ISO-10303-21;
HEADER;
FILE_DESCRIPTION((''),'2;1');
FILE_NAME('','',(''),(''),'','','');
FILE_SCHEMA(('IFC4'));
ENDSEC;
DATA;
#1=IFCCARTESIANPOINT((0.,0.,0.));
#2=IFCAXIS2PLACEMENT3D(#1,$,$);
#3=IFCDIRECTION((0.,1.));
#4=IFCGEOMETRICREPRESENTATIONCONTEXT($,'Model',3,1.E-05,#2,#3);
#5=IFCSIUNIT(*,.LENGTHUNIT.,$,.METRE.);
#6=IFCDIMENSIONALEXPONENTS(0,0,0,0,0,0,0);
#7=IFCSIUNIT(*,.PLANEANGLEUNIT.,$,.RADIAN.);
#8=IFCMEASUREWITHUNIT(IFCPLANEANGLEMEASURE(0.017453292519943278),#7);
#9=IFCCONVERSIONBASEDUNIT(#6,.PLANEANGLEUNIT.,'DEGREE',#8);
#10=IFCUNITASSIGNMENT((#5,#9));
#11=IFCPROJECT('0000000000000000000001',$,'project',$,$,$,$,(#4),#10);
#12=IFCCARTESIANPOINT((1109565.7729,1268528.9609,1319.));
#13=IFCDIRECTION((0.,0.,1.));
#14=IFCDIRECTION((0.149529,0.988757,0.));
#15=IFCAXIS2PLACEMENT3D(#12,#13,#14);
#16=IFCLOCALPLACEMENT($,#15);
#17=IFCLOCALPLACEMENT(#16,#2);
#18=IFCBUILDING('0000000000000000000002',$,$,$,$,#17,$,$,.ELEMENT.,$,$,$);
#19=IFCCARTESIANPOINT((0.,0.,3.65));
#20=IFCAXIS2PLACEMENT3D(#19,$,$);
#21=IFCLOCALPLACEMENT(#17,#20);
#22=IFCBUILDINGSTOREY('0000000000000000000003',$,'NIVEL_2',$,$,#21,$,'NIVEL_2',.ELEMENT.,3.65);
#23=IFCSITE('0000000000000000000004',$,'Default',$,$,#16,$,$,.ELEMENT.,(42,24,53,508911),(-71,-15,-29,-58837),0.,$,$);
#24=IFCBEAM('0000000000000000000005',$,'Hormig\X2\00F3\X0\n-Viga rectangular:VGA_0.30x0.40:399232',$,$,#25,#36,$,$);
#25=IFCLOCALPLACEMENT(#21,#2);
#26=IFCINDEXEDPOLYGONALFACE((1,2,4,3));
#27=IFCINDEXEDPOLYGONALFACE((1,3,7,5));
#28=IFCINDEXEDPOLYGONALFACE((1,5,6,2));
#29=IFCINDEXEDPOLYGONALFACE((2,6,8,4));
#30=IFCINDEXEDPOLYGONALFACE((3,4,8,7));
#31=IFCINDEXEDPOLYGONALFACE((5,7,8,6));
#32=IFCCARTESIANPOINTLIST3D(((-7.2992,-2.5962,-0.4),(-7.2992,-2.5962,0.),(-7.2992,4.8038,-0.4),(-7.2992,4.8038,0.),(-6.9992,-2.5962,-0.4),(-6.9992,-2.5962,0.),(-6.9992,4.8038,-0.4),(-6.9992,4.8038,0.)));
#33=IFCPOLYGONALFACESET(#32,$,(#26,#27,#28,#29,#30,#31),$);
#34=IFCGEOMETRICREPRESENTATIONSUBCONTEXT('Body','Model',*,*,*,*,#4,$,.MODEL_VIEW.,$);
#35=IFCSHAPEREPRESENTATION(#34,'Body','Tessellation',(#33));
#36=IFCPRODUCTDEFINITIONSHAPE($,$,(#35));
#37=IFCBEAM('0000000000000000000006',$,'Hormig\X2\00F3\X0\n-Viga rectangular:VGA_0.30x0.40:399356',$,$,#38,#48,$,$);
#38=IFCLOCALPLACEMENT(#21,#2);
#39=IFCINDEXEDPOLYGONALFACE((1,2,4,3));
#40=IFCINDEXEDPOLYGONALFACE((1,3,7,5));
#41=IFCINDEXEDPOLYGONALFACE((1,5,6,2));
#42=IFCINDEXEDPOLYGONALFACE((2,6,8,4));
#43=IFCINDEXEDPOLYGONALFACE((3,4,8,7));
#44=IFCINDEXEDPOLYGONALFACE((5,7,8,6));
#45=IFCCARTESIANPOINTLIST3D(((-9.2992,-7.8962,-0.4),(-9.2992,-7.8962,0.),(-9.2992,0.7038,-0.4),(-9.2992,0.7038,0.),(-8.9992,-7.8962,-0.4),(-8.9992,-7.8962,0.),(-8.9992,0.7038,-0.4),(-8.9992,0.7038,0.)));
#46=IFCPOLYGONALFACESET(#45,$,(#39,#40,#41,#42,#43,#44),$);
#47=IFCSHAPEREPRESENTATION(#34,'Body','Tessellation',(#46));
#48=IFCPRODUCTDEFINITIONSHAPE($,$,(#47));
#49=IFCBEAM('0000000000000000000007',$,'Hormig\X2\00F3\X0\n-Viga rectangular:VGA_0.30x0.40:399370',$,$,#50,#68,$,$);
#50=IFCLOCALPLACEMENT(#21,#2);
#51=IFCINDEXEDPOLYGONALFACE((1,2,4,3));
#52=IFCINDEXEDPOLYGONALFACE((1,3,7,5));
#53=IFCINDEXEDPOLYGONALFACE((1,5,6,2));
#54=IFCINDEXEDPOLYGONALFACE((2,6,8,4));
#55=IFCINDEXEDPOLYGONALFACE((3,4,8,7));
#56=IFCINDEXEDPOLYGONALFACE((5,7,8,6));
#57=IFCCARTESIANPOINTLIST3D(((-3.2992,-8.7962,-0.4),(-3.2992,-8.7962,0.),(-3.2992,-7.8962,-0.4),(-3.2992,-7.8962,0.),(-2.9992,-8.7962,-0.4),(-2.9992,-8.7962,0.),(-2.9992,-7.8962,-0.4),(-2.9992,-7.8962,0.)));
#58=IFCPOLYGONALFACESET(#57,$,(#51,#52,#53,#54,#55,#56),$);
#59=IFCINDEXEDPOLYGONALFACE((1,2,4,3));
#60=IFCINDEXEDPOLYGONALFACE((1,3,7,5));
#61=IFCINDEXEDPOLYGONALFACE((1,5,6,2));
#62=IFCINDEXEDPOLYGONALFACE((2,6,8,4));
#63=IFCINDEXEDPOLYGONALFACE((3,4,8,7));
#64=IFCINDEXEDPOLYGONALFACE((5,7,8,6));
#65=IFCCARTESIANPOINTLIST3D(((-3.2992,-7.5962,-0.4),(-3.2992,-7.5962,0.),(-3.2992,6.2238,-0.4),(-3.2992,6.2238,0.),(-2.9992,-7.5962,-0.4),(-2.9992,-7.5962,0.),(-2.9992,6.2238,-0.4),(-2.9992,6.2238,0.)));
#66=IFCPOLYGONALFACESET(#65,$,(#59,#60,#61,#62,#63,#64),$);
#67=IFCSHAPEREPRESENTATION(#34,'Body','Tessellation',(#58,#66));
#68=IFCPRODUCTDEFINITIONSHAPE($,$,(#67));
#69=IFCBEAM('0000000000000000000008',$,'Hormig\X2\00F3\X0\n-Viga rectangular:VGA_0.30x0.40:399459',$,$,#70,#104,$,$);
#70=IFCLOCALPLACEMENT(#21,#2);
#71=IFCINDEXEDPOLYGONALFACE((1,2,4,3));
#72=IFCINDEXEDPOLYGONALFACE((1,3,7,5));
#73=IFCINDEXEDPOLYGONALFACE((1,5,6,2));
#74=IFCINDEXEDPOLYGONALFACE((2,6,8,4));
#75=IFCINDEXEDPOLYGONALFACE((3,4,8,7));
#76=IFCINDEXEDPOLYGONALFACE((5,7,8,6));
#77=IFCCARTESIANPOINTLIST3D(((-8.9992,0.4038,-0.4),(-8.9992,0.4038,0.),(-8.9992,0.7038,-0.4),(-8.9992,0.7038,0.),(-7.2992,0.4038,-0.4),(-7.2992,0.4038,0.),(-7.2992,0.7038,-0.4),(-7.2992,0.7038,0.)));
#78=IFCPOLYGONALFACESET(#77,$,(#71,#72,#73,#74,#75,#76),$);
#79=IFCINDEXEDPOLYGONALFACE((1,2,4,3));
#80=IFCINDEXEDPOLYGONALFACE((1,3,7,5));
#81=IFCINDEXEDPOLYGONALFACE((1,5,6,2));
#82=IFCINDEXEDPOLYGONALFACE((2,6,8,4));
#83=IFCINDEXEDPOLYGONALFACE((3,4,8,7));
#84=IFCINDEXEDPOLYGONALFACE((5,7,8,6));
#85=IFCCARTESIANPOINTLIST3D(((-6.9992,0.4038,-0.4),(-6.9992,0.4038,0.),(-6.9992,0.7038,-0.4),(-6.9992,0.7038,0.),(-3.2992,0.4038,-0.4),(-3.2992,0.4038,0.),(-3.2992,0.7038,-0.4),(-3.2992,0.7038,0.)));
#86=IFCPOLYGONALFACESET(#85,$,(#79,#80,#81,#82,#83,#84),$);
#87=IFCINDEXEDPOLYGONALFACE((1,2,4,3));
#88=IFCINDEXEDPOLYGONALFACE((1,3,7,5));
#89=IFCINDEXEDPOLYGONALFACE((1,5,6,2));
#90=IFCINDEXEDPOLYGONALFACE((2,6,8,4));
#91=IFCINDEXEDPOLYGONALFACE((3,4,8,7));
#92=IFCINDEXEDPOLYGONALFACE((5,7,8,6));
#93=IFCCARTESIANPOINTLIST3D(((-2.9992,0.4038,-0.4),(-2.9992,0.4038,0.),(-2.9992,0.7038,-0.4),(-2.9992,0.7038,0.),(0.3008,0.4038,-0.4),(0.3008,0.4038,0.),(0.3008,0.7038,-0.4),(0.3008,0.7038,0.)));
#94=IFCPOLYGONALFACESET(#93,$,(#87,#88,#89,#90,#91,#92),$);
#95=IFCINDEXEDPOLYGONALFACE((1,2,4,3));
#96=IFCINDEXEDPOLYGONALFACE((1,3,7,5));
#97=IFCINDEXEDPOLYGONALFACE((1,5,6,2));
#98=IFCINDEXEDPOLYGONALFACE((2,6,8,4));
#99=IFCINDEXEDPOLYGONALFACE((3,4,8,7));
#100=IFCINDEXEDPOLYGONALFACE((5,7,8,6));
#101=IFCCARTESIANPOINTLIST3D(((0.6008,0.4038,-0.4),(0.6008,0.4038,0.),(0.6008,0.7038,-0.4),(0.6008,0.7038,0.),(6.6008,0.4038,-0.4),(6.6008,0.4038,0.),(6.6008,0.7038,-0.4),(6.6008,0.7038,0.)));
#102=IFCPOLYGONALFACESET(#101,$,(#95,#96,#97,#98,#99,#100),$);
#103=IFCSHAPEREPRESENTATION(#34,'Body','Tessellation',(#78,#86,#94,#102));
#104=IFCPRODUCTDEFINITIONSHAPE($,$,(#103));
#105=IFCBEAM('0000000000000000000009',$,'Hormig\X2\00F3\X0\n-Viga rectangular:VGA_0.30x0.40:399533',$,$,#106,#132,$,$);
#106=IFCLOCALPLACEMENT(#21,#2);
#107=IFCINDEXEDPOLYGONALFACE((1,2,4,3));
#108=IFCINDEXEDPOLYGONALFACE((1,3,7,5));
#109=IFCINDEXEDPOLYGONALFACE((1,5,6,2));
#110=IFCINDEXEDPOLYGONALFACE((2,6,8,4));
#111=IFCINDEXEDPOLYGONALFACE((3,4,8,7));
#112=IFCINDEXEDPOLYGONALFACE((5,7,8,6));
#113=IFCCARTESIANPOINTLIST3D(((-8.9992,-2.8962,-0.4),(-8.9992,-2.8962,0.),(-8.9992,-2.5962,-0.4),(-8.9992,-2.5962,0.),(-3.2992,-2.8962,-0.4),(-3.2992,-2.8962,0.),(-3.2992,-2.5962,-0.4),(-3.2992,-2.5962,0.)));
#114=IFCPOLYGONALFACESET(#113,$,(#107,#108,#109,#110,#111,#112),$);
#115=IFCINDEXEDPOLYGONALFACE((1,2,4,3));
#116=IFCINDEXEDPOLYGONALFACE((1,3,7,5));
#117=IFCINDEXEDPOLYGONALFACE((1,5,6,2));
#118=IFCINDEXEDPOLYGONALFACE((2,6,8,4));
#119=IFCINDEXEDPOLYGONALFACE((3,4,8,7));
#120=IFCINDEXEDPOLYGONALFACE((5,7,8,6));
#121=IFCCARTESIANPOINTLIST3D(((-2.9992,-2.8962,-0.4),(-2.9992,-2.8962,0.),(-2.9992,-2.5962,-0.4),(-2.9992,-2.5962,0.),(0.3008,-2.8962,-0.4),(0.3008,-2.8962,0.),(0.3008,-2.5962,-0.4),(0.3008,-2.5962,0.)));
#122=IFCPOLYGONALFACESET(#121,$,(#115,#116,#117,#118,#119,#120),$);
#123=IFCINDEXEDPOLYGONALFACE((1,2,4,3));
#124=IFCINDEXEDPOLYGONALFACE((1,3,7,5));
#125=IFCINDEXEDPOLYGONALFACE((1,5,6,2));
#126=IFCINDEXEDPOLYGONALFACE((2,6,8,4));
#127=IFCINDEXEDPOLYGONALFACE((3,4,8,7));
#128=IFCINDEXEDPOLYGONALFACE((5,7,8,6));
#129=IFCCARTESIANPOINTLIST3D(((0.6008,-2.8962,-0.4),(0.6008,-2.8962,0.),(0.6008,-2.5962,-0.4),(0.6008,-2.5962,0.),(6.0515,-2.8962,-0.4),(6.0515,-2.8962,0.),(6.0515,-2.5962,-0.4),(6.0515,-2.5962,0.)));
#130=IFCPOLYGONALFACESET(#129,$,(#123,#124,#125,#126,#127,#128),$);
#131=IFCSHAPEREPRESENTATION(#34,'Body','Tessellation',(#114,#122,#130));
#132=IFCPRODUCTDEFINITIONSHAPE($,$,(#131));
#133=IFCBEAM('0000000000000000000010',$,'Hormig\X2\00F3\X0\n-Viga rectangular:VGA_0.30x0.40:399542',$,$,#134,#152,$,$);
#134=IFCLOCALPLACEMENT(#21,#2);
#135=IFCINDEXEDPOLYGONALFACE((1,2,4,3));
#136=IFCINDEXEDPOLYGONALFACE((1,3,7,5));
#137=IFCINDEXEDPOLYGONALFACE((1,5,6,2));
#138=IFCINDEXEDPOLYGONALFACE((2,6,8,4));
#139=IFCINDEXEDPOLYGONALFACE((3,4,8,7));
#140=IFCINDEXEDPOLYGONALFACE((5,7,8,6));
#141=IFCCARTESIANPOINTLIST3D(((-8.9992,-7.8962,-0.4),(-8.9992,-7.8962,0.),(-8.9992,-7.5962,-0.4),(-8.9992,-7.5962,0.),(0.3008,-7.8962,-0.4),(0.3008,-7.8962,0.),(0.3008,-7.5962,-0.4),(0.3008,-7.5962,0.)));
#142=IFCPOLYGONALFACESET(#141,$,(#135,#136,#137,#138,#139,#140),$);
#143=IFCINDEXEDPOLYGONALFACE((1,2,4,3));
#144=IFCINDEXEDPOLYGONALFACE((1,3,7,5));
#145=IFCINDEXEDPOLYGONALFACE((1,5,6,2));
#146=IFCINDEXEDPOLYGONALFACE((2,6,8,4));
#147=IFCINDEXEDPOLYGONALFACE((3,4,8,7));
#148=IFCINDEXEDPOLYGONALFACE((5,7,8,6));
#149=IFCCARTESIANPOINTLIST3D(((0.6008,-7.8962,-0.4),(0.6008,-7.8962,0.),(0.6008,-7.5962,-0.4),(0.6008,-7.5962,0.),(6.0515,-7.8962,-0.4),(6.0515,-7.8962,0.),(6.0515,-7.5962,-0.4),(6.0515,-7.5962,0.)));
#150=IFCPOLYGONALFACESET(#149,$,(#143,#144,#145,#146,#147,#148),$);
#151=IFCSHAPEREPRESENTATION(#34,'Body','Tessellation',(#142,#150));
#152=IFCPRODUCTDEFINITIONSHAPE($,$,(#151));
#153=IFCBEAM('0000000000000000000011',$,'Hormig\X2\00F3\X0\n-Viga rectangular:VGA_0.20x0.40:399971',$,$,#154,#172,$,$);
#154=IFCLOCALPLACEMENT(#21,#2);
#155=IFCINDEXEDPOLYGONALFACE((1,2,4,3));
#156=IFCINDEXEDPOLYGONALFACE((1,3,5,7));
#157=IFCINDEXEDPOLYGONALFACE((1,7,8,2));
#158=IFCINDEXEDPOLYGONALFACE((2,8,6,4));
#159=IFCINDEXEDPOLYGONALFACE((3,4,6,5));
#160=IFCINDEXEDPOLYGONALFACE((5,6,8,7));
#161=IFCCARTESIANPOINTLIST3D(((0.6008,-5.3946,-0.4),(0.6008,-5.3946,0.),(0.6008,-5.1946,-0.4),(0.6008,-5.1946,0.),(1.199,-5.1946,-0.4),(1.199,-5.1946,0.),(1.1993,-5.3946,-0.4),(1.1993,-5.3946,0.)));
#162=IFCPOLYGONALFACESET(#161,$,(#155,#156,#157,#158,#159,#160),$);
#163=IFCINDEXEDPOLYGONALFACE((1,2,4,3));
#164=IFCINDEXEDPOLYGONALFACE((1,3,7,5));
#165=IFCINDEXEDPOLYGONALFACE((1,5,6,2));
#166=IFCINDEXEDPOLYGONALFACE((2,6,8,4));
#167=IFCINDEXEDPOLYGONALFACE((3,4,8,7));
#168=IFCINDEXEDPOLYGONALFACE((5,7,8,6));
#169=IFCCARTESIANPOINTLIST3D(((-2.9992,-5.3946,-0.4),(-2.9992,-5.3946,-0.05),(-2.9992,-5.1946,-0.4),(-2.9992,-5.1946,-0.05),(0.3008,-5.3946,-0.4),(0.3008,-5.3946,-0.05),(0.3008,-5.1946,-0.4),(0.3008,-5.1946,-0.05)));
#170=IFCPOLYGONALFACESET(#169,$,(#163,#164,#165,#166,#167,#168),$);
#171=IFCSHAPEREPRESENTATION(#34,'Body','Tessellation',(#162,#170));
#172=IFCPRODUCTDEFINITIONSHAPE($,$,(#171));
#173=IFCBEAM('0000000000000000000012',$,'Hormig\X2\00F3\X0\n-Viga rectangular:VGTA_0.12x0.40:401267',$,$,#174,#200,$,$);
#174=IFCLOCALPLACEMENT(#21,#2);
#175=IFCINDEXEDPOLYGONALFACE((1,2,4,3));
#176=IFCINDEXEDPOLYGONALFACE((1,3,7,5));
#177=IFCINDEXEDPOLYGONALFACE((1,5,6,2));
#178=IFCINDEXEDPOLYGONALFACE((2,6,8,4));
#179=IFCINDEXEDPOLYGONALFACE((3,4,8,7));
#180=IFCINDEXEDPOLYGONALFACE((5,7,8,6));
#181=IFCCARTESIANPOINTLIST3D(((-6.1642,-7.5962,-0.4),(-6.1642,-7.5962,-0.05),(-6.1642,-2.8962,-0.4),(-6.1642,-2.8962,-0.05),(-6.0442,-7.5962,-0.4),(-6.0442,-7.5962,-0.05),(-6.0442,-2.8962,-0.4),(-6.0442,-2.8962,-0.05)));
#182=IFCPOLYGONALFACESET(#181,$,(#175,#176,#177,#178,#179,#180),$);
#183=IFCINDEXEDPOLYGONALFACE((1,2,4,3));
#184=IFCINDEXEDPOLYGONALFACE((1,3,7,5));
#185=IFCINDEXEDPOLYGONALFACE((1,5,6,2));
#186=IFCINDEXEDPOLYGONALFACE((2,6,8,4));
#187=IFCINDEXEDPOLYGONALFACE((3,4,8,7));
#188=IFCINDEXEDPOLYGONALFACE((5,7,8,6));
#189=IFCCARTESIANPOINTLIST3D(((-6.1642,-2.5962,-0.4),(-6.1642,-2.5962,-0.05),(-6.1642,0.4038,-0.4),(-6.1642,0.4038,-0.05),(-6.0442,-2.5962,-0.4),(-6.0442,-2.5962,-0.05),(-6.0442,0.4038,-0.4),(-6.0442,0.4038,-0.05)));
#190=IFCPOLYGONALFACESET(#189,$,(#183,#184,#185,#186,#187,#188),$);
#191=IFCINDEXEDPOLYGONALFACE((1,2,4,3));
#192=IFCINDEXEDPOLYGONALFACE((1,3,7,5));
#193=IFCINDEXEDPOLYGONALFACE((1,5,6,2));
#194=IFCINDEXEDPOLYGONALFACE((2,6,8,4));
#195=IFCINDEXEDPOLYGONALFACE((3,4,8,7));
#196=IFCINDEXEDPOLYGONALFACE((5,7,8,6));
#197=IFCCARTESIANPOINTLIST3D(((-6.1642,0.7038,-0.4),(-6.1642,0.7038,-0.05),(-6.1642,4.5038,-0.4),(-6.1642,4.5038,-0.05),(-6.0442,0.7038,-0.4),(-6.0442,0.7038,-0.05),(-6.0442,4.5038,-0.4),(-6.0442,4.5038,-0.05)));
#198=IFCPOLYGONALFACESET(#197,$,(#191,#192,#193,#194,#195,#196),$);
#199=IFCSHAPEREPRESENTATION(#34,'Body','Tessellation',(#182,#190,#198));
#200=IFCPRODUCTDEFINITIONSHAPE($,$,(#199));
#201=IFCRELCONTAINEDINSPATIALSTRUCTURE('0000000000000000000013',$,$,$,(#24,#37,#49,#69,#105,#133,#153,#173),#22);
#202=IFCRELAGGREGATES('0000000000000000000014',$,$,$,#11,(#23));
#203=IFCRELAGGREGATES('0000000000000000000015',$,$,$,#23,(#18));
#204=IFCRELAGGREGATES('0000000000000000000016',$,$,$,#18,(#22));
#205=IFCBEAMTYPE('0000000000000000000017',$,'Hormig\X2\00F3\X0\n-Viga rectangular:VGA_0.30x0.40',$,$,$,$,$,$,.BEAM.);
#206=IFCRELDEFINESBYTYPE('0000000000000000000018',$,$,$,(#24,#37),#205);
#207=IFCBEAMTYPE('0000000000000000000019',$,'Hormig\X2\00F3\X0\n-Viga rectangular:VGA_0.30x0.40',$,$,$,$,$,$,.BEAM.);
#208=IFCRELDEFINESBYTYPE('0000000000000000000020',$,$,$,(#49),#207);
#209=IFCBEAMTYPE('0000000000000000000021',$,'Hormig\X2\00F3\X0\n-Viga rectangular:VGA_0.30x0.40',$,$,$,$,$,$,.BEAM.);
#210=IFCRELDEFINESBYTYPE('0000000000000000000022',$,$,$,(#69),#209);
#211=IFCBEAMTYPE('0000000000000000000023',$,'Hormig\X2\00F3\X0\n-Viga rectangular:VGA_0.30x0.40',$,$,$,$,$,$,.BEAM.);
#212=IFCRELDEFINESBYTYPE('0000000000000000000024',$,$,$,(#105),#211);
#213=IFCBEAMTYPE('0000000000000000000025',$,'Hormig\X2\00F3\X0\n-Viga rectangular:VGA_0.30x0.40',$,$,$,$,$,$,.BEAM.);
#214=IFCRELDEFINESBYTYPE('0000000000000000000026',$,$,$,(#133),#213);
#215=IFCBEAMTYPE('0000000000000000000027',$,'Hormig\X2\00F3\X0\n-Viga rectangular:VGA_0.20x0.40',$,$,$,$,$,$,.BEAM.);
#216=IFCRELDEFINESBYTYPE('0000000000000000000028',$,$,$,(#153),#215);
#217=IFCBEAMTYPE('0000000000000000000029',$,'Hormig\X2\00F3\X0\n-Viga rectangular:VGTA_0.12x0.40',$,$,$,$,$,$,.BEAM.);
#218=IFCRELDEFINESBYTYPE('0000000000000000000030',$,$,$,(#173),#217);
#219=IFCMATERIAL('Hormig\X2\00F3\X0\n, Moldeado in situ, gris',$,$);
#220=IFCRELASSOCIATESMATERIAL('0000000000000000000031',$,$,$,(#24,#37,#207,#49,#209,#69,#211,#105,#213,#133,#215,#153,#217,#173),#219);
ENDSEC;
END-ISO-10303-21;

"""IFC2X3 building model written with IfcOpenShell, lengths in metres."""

from ifc_helpers import new_model, entity, si_unit, converted_unit, direction, frame, frame_2d, origin, origin_2d_with_axis, place, context, subcontext, project, spatial, rectangle, extrude, clip, halfspace, source, transform, mapped, material, type_object, type_shapes, element, save


model = new_model("IFC2X3")

# Units and contexts
model_context = context("Model", 3, precision=1e-05, world=origin(), true_north=direction((0.0, 1.0)))
body_context = subcontext(model_context, "Body", "Model", "MODEL_VIEW")
ifc_project = project(units=[si_unit("LENGTHUNIT", "METRE"), converted_unit("PLANEANGLEUNIT", "DEGREE", entity("IfcPlaneAngleMeasure", 0.017453292519943278), si_unit("PLANEANGLEUNIT", "RADIAN"), dimensions=[0, 0, 0, 0, 0, 0, 0])], contexts=[model_context])

# Site, building, storey
site_placement = place(None, frame((1109565.7729, 1268528.9609, 1319.0), z_axis=(0.0, 0.0, 1.0), x_axis=(0.149529, 0.988757, 0.0)))
site = spatial("IfcSite", under=ifc_project, at=site_placement, Name="Default", CompositionType="ELEMENT", RefLatitude=(42, 24, 53, 508911), RefLongitude=(-71, -15, -29, -58837), RefElevation=0.0)
building_placement = place(site_placement, origin())
building = spatial("IfcBuilding", under=site, at=building_placement, CompositionType="ELEMENT")
storey_placement = place(building_placement, frame((0.0, 0.0, 3.65)))
storey = spatial("IfcBuildingStorey", under=building, at=storey_placement, Name="NIVEL_2", LongName="NIVEL_2", CompositionType="ELEMENT", Elevation=3.65)

# Shared definitions
ifc_material_1 = material(Name="Hormigón, Moldeado in situ, gris")

# Beams
beam_type_1 = type_object("IfcBeamType", Name="Hormigón-Viga rectangular:VGA_0.30x0.40", PredefinedType="BEAM")
beam_1_placement = place(storey_placement, frame((-7.1492, 4.6538, 0.0), z_axis=(0.0, 0.0, 1.0), x_axis=(0.0, -1.0, 0.0)))
element("IfcBeam", 1, at=beam_1_placement, inside=storey, type_object=beam_type_1, material=ifc_material_1, Name="Hormigón-Viga rectangular:VGA_0.30x0.40:399232", context=body_context, shape_type="SweptSolid", body=[
    extrude(rectangle(XDim=0.4, YDim=0.3, at=origin_2d_with_axis()), frame((-0.15, 0.0, -0.2), z_axis=(1.0, 0.0, 0.0), x_axis=(0.0, 0.0, -1.0)), (0.0, 0.0, 1.0), 7.4),
])
beam_2_placement = place(storey_placement, frame((-9.1492, 0.5538, 0.0), z_axis=(0.0, 0.0, 1.0), x_axis=(0.0, -1.0, 0.0)))
element("IfcBeam", 2, at=beam_2_placement, inside=storey, type_object=beam_type_1, material=ifc_material_1, Name="Hormigón-Viga rectangular:VGA_0.30x0.40:399356", context=body_context, shape_type="SweptSolid", body=[
    extrude(rectangle(XDim=0.4, YDim=0.3, at=frame_2d((0.0, 0.0), x_axis=(1.0, 0.0))), frame((-0.15, 0.0, -0.2), z_axis=(1.0, 0.0, 0.0), x_axis=(0.0, 0.0, -1.0)), (0.0, 0.0, 1.0), 8.6),
])
beam_type_2 = type_object("IfcBeamType", Name="Hormigón-Viga rectangular:VGA_0.30x0.40", PredefinedType="BEAM", material=ifc_material_1)
shared_shape_1 = source(origin(), body_context, "Body", "SweptSolid", [
    extrude(rectangle(XDim=0.4, YDim=0.3, at=frame_2d((0.0, 0.0), x_axis=(0.0, 1.0))), frame((-3.1492, -7.8962, 3.45), z_axis=(0.0, -1.0, 0.0), x_axis=(-1.0, 0.0, 0.0)), (0.0, 0.0, 1.0), 0.9),
    extrude(rectangle(XDim=0.4, YDim=0.3, at=frame_2d((0.0, 0.0), x_axis=(0.0, 1.0))), frame((-3.1492, 6.2238, 3.45), z_axis=(0.0, -1.0, 0.0), x_axis=(-1.0, 0.0, 0.0)), (0.0, 0.0, 1.0), 13.82),
])
type_shapes(beam_type_2, [shared_shape_1])
beam_3_placement = place(storey_placement, frame((0.0, 0.0, -3.65)))
element("IfcBeam", 3, at=beam_3_placement, inside=storey, type_object=beam_type_2, material=ifc_material_1, Name="Hormigón-Viga rectangular:VGA_0.30x0.40:399370", context=body_context, shape_type="MappedRepresentation", body=[
    mapped(shared_shape_1, transform((0.0, 0.0, 0.0), scale=1.0)),
])
beam_type_3 = type_object("IfcBeamType", Name="Hormigón-Viga rectangular:VGA_0.30x0.40", PredefinedType="BEAM", material=ifc_material_1)
shared_shape_2 = source(origin(), body_context, "Body", "SweptSolid", [
    extrude(rectangle(XDim=0.4, YDim=0.3, at=frame_2d((0.0, 0.0), x_axis=(1.0, 0.0))), frame((-8.9992, 0.5538, 3.45), z_axis=(1.0, 0.0, 0.0), x_axis=(0.0, 0.0, -1.0)), (0.0, 0.0, 1.0), 1.7),
    extrude(rectangle(XDim=0.4, YDim=0.3, at=frame_2d((0.0, 0.0), x_axis=(1.0, 0.0))), frame((-6.9992, 0.5538, 3.45), z_axis=(1.0, 0.0, 0.0), x_axis=(0.0, 0.0, -1.0)), (0.0, 0.0, 1.0), 3.7),
    extrude(rectangle(XDim=0.4, YDim=0.3, at=origin_2d_with_axis()), frame((-2.9992, 0.5538, 3.45), z_axis=(1.0, 0.0, 0.0), x_axis=(0.0, 0.0, -1.0)), (0.0, 0.0, 1.0), 3.3),
    extrude(rectangle(XDim=0.4, YDim=0.3, at=origin_2d_with_axis()), frame((0.6008, 0.5538, 3.45), z_axis=(1.0, 0.0, 0.0), x_axis=(0.0, 0.0, -1.0)), (0.0, 0.0, 1.0), 6.0),
])
type_shapes(beam_type_3, [shared_shape_2])
beam_4_placement = place(storey_placement, frame((0.0, 0.0, -3.65)))
element("IfcBeam", 4, at=beam_4_placement, inside=storey, type_object=beam_type_3, material=ifc_material_1, Name="Hormigón-Viga rectangular:VGA_0.30x0.40:399459", context=body_context, shape_type="MappedRepresentation", body=[
    mapped(shared_shape_2, transform((0.0, 0.0, 0.0), scale=1.0)),
])
beam_type_4 = type_object("IfcBeamType", Name="Hormigón-Viga rectangular:VGA_0.30x0.40", PredefinedType="BEAM", material=ifc_material_1)
shared_shape_3 = source(origin(), body_context, "Body", "SweptSolid", [
    extrude(rectangle(XDim=0.4, YDim=0.3, at=origin_2d_with_axis()), frame((-8.9992, -2.7462, 3.45), z_axis=(1.0, 0.0, 0.0), x_axis=(0.0, 0.0, -1.0)), (0.0, 0.0, 1.0), 5.7),
    extrude(rectangle(XDim=0.4, YDim=0.3, at=origin_2d_with_axis()), frame((-2.9992, -2.7462, 3.45), z_axis=(1.0, 0.0, 0.0), x_axis=(0.0, 0.0, -1.0)), (0.0, 0.0, 1.0), 3.3),
    extrude(rectangle(XDim=0.4, YDim=0.3, at=origin_2d_with_axis()), frame((0.6008, -2.7462, 3.45), z_axis=(1.0, 0.0, 0.0), x_axis=(0.0, 0.0, -1.0)), (0.0, 0.0, 1.0), 5.4507),
])
type_shapes(beam_type_4, [shared_shape_3])
beam_5_placement = place(storey_placement, frame((0.0, 0.0, -3.65)))
element("IfcBeam", 5, at=beam_5_placement, inside=storey, type_object=beam_type_4, material=ifc_material_1, Name="Hormigón-Viga rectangular:VGA_0.30x0.40:399533", context=body_context, shape_type="MappedRepresentation", body=[
    mapped(shared_shape_3, transform((0.0, 0.0, 0.0), scale=1.0)),
])
beam_type_5 = type_object("IfcBeamType", Name="Hormigón-Viga rectangular:VGA_0.30x0.40", PredefinedType="BEAM", material=ifc_material_1)
shared_shape_4 = source(origin(), body_context, "Body", "SweptSolid", [
    extrude(rectangle(XDim=0.4, YDim=0.3, at=frame_2d((0.0, 0.0), x_axis=(1.0, 0.0))), frame((-8.9992, -7.7462, 3.45), z_axis=(1.0, 0.0, 0.0), x_axis=(0.0, 0.0, -1.0)), (0.0, 0.0, 1.0), 9.3),
    extrude(rectangle(XDim=0.4, YDim=0.3, at=frame_2d((0.0, 0.0), x_axis=(1.0, 0.0))), frame((0.6008, -7.7462, 3.45), z_axis=(1.0, 0.0, 0.0), x_axis=(0.0, 0.0, -1.0)), (0.0, 0.0, 1.0), 5.4507),
])
type_shapes(beam_type_5, [shared_shape_4])
beam_6_placement = place(storey_placement, frame((0.0, 0.0, -3.65)))
element("IfcBeam", 6, at=beam_6_placement, inside=storey, type_object=beam_type_5, material=ifc_material_1, Name="Hormigón-Viga rectangular:VGA_0.30x0.40:399542", context=body_context, shape_type="MappedRepresentation", body=[
    mapped(shared_shape_4, transform((0.0, 0.0, 0.0), scale=1.0)),
])
beam_type_6 = type_object("IfcBeamType", Name="Hormigón-Viga rectangular:VGA_0.20x0.40", PredefinedType="BEAM", material=ifc_material_1)
shared_shape_5 = source(origin(), body_context, "Body", "SweptSolid", [
    clip(extrude(rectangle(XDim=0.4, YDim=0.2, at=frame_2d((0.0, 0.0), x_axis=(1.0, 0.0))), frame((0.6008, -5.2946, 3.45), z_axis=(1.0, 0.0, 0.0), x_axis=(0.0, 0.0, -1.0)), (0.0, 0.0, 1.0), 0.5985), halfspace(frame((1.199, -5.1946, 3.65), z_axis=(0.999999, 0.001387, 0.0), x_axis=(0.001387, -0.999999, 0.0)), False)),
    extrude(rectangle(XDim=0.35, YDim=0.2, at=frame_2d((0.0, 0.0), x_axis=(1.0, 0.0))), frame((-2.9992, -5.2946, 3.425), z_axis=(1.0, 0.0, 0.0), x_axis=(0.0, 0.0, -1.0)), (0.0, 0.0, 1.0), 3.3),
])
type_shapes(beam_type_6, [shared_shape_5])
beam_7_placement = place(storey_placement, frame((0.0, 0.0, -3.65)))
element("IfcBeam", 7, at=beam_7_placement, inside=storey, type_object=beam_type_6, material=ifc_material_1, Name="Hormigón-Viga rectangular:VGA_0.20x0.40:399971", context=body_context, shape_type="MappedRepresentation", body=[
    mapped(shared_shape_5, transform((0.0, 0.0, 0.0), scale=1.0)),
])
beam_type_7 = type_object("IfcBeamType", Name="Hormigón-Viga rectangular:VGTA_0.12x0.40", PredefinedType="BEAM", material=ifc_material_1)
shared_shape_6 = source(origin(), body_context, "Body", "SweptSolid", [
    extrude(rectangle(XDim=0.35, YDim=0.12, at=frame_2d((0.0, 0.0), x_axis=(0.0, 1.0))), frame((-6.1042, -7.5962, 3.425), z_axis=(0.0, 1.0, 0.0), x_axis=(-1.0, 0.0, 0.0)), (0.0, 0.0, 1.0), 4.7),
    extrude(rectangle(XDim=0.35, YDim=0.12, at=frame_2d((0.0, 0.0), x_axis=(0.0, 1.0))), frame((-6.1042, -2.5962, 3.425), z_axis=(0.0, 1.0, 0.0), x_axis=(-1.0, 0.0, 0.0)), (0.0, 0.0, 1.0), 3.0),
    extrude(rectangle(XDim=0.35, YDim=0.12, at=frame_2d((0.0, 0.0), x_axis=(0.0, 1.0))), frame((-6.1042, 0.7038, 3.425), z_axis=(0.0, 1.0, 0.0), x_axis=(-1.0, 0.0, 0.0)), (0.0, 0.0, 1.0), 3.8),
])
type_shapes(beam_type_7, [shared_shape_6])
beam_8_placement = place(storey_placement, frame((0.0, 0.0, -3.65)))
element("IfcBeam", 8, at=beam_8_placement, inside=storey, type_object=beam_type_7, material=ifc_material_1, Name="Hormigón-Viga rectangular:VGTA_0.12x0.40:401267", context=body_context, shape_type="MappedRepresentation", body=[
    mapped(shared_shape_6, transform((0.0, 0.0, 0.0), scale=1.0)),
])

save(model, "model.ifc")
